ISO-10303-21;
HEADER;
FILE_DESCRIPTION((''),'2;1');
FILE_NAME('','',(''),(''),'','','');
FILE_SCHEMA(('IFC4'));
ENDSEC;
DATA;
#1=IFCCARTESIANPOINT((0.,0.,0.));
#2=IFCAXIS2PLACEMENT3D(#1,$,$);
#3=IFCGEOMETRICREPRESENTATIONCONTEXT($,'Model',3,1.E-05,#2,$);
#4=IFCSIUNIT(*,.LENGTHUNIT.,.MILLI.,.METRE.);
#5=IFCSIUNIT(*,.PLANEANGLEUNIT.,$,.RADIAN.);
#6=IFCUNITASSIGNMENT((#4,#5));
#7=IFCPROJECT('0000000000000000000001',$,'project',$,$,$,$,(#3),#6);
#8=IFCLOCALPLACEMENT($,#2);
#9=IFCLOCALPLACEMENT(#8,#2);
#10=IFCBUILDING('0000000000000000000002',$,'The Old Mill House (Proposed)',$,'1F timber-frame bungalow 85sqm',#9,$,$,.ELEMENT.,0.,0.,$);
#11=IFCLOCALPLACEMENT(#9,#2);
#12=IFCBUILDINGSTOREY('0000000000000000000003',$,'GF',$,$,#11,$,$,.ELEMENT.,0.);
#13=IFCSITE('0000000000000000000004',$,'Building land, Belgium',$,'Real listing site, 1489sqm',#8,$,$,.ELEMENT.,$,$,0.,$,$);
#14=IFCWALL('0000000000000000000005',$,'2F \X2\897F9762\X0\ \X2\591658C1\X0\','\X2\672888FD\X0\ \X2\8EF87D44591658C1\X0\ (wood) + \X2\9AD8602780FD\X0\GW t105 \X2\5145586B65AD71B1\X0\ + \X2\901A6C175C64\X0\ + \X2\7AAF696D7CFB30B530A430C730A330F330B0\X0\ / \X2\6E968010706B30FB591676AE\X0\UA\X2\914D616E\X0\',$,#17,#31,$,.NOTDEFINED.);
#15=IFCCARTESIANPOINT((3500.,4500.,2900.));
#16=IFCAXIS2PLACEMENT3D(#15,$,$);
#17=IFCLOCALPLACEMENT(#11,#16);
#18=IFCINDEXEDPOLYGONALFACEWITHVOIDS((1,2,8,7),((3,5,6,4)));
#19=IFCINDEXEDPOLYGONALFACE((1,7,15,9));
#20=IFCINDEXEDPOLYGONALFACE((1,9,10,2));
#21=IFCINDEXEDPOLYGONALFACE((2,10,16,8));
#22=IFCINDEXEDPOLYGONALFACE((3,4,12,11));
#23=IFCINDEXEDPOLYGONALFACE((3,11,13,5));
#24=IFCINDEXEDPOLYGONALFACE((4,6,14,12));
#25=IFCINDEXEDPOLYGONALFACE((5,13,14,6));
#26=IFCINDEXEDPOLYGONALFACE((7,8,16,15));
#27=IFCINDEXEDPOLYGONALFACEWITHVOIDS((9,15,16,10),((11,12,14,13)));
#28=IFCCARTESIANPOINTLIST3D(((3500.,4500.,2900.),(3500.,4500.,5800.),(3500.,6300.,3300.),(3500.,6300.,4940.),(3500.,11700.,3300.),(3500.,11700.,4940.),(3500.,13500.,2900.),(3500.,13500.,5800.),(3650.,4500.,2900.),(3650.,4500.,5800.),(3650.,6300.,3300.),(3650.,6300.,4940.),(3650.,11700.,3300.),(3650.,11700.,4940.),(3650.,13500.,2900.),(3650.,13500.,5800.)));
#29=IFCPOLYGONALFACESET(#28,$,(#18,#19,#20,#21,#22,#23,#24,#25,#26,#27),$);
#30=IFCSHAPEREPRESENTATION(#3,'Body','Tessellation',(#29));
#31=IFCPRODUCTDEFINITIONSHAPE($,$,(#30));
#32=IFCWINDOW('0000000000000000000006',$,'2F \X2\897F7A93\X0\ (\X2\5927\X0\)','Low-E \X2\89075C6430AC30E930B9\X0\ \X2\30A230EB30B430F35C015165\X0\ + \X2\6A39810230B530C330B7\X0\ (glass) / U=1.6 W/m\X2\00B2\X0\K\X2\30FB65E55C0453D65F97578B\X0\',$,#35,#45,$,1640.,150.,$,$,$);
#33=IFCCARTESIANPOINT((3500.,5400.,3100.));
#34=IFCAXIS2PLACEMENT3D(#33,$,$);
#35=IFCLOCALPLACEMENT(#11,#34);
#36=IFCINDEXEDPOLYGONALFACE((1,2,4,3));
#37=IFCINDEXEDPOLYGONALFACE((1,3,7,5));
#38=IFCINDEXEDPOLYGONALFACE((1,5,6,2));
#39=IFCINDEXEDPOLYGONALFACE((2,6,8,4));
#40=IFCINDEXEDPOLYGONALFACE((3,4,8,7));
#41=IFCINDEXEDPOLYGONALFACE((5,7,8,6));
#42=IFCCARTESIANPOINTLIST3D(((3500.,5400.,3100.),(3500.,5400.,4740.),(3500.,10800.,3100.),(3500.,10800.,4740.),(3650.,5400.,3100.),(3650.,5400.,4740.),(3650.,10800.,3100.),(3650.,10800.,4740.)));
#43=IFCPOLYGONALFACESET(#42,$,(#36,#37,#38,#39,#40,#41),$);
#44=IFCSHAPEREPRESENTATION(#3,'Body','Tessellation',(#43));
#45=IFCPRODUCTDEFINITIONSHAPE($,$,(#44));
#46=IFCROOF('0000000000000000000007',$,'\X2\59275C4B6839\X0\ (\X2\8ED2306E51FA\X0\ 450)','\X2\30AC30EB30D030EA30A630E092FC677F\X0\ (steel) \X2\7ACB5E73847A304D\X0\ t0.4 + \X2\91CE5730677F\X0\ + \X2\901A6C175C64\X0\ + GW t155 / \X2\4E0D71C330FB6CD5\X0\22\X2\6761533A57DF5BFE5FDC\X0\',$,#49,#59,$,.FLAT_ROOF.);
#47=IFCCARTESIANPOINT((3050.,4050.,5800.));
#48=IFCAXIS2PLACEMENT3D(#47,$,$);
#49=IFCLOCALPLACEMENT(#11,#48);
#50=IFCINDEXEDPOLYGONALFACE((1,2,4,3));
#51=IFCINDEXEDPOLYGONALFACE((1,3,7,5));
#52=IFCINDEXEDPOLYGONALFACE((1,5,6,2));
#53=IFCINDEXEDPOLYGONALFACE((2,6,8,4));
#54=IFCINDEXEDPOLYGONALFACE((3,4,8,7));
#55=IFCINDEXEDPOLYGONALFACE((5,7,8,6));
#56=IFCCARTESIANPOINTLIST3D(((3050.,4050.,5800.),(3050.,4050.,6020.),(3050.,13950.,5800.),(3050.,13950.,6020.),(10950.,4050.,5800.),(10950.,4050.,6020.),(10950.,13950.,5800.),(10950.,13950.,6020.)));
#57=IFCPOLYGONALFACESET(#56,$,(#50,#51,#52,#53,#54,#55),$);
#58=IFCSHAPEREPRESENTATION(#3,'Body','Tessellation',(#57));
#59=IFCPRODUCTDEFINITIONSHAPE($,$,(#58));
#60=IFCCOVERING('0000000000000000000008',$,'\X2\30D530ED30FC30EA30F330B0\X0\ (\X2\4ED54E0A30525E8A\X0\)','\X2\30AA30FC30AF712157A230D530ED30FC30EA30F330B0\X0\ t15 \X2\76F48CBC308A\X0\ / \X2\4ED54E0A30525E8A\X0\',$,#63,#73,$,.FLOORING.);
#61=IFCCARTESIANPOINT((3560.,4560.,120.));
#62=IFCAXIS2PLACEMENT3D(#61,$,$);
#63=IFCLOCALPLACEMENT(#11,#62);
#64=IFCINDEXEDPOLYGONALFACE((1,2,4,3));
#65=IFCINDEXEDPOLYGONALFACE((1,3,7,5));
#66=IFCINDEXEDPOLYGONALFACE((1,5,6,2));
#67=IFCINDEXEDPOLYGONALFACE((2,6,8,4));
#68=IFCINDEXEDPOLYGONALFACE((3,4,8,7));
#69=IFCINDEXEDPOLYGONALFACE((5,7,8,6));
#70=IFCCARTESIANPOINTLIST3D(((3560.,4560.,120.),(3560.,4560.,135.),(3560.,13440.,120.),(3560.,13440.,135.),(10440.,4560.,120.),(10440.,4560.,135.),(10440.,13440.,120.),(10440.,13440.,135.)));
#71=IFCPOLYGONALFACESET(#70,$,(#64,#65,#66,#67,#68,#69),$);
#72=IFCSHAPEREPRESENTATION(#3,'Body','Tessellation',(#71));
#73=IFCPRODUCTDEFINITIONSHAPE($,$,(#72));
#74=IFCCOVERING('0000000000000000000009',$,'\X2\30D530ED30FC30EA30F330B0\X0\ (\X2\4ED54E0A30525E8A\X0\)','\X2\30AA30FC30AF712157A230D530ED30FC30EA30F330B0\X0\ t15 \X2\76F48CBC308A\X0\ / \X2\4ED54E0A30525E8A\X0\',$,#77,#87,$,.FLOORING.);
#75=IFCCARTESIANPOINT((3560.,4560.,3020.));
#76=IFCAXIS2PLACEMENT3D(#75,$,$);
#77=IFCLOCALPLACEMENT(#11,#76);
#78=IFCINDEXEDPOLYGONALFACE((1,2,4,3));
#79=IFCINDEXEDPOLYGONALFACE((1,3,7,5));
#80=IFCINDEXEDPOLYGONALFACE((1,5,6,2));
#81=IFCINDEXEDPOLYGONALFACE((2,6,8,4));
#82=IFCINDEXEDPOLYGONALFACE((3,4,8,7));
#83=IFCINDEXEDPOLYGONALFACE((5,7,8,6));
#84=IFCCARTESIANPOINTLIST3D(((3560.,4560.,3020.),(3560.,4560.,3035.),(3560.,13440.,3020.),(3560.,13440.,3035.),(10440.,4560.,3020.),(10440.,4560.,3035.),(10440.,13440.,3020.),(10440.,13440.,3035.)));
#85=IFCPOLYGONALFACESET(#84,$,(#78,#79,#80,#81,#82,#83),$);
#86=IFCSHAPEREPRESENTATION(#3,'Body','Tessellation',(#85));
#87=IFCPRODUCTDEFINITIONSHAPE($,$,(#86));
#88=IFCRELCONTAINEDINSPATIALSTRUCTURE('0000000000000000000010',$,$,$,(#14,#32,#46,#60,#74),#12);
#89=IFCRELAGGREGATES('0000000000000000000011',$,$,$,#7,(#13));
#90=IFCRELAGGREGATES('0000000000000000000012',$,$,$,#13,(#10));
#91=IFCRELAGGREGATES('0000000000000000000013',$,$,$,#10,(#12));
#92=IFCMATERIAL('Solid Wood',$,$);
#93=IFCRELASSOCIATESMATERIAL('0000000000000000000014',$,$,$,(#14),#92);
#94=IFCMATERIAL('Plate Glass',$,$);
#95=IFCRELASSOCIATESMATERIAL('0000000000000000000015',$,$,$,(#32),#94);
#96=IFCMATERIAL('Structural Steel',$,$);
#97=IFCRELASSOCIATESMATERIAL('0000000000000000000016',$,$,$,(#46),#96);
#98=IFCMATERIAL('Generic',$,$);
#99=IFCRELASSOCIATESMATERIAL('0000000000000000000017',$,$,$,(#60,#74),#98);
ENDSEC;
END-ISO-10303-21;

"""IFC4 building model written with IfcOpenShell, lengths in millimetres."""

from ifc_helpers import new_model, si_unit, frame, frame_2d, origin, place, context, project, spatial, rectangle, extrude, material, element, fill, save


model = new_model("IFC4")

# Units and contexts
model_context = context("Model", 3, precision=1e-05, world=origin())
ifc_project = project(units=[si_unit("LENGTHUNIT", "METRE", prefix="MILLI"), si_unit("PLANEANGLEUNIT", "RADIAN")], contexts=[model_context])

# Site, building, storey
site_placement = place(None, origin())
site = spatial("IfcSite", under=ifc_project, at=site_placement, Name="Building land, Belgium", ObjectType="Real listing site, 1489sqm", CompositionType="ELEMENT", RefElevation=0.0)
building_placement = place(site_placement, origin())
building = spatial("IfcBuilding", under=site, at=building_placement, Name="The Old Mill House (Proposed)", ObjectType="1F timber-frame bungalow 85sqm", CompositionType="ELEMENT", ElevationOfRefHeight=0.0, ElevationOfTerrain=0.0)
storey_placement = place(building_placement, origin())
storey = spatial("IfcBuildingStorey", under=building, at=storey_placement, Name="GF", CompositionType="ELEMENT", Elevation=0.0)

# Shared definitions
ifc_material_1 = material(Name="Solid Wood")
ifc_material_2 = material(Name="Generic")

# Shared definitions
ifc_material_3 = material(Name="Plate Glass")

# Wall, opening, window
wall_1_placement = place(storey_placement, frame((3500.0, 4500.0, 2900.0)))
wall_1 = element("IfcWall", 1, at=wall_1_placement, inside=storey, material=ifc_material_1, Name="2F 西面 外壁", Description="木製 軸組外壁 (wood) + 高性能GW t105 充填断熱 + 通気層 + 窯業系サイディング / 準耐火・外皮UA配慮", PredefinedType="NOTDEFINED", context=model_context, shape_type="SweptSolid", body=[
    extrude(rectangle(XDim=150.0, YDim=9000.0, at=frame_2d((75.0, 4500.0))), frame((3500.0, 4500.0, 2900.0)), (0.0, 0.0, 1.0), 2900.0),
])
opening_1_placement = place(storey_placement, frame((3500.0, 5400.0, 3100.0)))
opening_1 = element("IfcOpeningElement", 2, at=opening_1_placement, cuts=wall_1, PredefinedType="NOTDEFINED", context=model_context, shape_type="SweptSolid", body=[
    extrude(rectangle(XDim=150.0, YDim=5400.0, at=frame_2d((75.0, 2700.0))), frame((3500.0, 5400.0, 3100.0)), (0.0, 0.0, 1.0), 1640.0),
])
window_1_placement = place(storey_placement, frame((3500.0, 5400.0, 3100.0)))
window_1 = element("IfcWindow", 3, at=window_1_placement, inside=storey, material=ifc_material_3, Name="2F 西窓 (大)", Description="Low-E 複層ガラス アルゴン封入 + 樹脂サッシ (glass) / U=1.6 W/m²K・日射取得型", OverallHeight=1640.0, OverallWidth=150.0, context=model_context, shape_type="SweptSolid", body=[
    extrude(rectangle(XDim=150.0, YDim=5400.0, at=frame_2d((75.0, 2700.0))), frame((3500.0, 5400.0, 3100.0)), (0.0, 0.0, 1.0), 1640.0),
])
fill(opening_1, window_1)

# Roof
ifc_material_4 = material(Name="Structural Steel")
roof_placement = place(storey_placement, frame((3050.0, 4050.0, 5800.0)))
element("IfcRoof", 4, at=roof_placement, inside=storey, material=ifc_material_4, Name="大屋根 (軒の出 450)", Description="ガルバリウム鋼板 (steel) 立平葺き t0.4 + 野地板 + 通気層 + GW t155 / 不燃・法22条区域対応", PredefinedType="FLAT_ROOF", context=model_context, shape_type="SweptSolid", body=[
    extrude(rectangle(XDim=7900.0, YDim=9900.0, at=frame_2d((3950.0, 4950.0))), frame((3050.0, 4050.0, 5800.0)), (0.0, 0.0, 1.0), 220.0),
])

# Coverings
covering_1_placement = place(storey_placement, frame((3560.0, 4560.0, 120.0)))
element("IfcCovering", 5, at=covering_1_placement, inside=storey, material=ifc_material_2, Name="フローリング (仕上げ床)", Description="オーク無垢フローリング t15 直貼り / 仕上げ床", PredefinedType="FLOORING", context=model_context, shape_type="SweptSolid", body=[
    extrude(rectangle(XDim=6880.0, YDim=8880.0, at=frame_2d((3440.0, 4440.0))), frame((3560.0, 4560.0, 120.0)), (0.0, 0.0, 1.0), 15.0),
])
covering_2_placement = place(storey_placement, frame((3560.0, 4560.0, 3020.0)))
element("IfcCovering", 6, at=covering_2_placement, inside=storey, material=ifc_material_2, Name="フローリング (仕上げ床)", Description="オーク無垢フローリング t15 直貼り / 仕上げ床", PredefinedType="FLOORING", context=model_context, shape_type="SweptSolid", body=[
    extrude(rectangle(XDim=6880.0, YDim=8880.0, at=frame_2d((3440.0, 4440.0))), frame((3560.0, 4560.0, 3020.0)), (0.0, 0.0, 1.0), 15.0),
])

save(model, "model.ifc")
